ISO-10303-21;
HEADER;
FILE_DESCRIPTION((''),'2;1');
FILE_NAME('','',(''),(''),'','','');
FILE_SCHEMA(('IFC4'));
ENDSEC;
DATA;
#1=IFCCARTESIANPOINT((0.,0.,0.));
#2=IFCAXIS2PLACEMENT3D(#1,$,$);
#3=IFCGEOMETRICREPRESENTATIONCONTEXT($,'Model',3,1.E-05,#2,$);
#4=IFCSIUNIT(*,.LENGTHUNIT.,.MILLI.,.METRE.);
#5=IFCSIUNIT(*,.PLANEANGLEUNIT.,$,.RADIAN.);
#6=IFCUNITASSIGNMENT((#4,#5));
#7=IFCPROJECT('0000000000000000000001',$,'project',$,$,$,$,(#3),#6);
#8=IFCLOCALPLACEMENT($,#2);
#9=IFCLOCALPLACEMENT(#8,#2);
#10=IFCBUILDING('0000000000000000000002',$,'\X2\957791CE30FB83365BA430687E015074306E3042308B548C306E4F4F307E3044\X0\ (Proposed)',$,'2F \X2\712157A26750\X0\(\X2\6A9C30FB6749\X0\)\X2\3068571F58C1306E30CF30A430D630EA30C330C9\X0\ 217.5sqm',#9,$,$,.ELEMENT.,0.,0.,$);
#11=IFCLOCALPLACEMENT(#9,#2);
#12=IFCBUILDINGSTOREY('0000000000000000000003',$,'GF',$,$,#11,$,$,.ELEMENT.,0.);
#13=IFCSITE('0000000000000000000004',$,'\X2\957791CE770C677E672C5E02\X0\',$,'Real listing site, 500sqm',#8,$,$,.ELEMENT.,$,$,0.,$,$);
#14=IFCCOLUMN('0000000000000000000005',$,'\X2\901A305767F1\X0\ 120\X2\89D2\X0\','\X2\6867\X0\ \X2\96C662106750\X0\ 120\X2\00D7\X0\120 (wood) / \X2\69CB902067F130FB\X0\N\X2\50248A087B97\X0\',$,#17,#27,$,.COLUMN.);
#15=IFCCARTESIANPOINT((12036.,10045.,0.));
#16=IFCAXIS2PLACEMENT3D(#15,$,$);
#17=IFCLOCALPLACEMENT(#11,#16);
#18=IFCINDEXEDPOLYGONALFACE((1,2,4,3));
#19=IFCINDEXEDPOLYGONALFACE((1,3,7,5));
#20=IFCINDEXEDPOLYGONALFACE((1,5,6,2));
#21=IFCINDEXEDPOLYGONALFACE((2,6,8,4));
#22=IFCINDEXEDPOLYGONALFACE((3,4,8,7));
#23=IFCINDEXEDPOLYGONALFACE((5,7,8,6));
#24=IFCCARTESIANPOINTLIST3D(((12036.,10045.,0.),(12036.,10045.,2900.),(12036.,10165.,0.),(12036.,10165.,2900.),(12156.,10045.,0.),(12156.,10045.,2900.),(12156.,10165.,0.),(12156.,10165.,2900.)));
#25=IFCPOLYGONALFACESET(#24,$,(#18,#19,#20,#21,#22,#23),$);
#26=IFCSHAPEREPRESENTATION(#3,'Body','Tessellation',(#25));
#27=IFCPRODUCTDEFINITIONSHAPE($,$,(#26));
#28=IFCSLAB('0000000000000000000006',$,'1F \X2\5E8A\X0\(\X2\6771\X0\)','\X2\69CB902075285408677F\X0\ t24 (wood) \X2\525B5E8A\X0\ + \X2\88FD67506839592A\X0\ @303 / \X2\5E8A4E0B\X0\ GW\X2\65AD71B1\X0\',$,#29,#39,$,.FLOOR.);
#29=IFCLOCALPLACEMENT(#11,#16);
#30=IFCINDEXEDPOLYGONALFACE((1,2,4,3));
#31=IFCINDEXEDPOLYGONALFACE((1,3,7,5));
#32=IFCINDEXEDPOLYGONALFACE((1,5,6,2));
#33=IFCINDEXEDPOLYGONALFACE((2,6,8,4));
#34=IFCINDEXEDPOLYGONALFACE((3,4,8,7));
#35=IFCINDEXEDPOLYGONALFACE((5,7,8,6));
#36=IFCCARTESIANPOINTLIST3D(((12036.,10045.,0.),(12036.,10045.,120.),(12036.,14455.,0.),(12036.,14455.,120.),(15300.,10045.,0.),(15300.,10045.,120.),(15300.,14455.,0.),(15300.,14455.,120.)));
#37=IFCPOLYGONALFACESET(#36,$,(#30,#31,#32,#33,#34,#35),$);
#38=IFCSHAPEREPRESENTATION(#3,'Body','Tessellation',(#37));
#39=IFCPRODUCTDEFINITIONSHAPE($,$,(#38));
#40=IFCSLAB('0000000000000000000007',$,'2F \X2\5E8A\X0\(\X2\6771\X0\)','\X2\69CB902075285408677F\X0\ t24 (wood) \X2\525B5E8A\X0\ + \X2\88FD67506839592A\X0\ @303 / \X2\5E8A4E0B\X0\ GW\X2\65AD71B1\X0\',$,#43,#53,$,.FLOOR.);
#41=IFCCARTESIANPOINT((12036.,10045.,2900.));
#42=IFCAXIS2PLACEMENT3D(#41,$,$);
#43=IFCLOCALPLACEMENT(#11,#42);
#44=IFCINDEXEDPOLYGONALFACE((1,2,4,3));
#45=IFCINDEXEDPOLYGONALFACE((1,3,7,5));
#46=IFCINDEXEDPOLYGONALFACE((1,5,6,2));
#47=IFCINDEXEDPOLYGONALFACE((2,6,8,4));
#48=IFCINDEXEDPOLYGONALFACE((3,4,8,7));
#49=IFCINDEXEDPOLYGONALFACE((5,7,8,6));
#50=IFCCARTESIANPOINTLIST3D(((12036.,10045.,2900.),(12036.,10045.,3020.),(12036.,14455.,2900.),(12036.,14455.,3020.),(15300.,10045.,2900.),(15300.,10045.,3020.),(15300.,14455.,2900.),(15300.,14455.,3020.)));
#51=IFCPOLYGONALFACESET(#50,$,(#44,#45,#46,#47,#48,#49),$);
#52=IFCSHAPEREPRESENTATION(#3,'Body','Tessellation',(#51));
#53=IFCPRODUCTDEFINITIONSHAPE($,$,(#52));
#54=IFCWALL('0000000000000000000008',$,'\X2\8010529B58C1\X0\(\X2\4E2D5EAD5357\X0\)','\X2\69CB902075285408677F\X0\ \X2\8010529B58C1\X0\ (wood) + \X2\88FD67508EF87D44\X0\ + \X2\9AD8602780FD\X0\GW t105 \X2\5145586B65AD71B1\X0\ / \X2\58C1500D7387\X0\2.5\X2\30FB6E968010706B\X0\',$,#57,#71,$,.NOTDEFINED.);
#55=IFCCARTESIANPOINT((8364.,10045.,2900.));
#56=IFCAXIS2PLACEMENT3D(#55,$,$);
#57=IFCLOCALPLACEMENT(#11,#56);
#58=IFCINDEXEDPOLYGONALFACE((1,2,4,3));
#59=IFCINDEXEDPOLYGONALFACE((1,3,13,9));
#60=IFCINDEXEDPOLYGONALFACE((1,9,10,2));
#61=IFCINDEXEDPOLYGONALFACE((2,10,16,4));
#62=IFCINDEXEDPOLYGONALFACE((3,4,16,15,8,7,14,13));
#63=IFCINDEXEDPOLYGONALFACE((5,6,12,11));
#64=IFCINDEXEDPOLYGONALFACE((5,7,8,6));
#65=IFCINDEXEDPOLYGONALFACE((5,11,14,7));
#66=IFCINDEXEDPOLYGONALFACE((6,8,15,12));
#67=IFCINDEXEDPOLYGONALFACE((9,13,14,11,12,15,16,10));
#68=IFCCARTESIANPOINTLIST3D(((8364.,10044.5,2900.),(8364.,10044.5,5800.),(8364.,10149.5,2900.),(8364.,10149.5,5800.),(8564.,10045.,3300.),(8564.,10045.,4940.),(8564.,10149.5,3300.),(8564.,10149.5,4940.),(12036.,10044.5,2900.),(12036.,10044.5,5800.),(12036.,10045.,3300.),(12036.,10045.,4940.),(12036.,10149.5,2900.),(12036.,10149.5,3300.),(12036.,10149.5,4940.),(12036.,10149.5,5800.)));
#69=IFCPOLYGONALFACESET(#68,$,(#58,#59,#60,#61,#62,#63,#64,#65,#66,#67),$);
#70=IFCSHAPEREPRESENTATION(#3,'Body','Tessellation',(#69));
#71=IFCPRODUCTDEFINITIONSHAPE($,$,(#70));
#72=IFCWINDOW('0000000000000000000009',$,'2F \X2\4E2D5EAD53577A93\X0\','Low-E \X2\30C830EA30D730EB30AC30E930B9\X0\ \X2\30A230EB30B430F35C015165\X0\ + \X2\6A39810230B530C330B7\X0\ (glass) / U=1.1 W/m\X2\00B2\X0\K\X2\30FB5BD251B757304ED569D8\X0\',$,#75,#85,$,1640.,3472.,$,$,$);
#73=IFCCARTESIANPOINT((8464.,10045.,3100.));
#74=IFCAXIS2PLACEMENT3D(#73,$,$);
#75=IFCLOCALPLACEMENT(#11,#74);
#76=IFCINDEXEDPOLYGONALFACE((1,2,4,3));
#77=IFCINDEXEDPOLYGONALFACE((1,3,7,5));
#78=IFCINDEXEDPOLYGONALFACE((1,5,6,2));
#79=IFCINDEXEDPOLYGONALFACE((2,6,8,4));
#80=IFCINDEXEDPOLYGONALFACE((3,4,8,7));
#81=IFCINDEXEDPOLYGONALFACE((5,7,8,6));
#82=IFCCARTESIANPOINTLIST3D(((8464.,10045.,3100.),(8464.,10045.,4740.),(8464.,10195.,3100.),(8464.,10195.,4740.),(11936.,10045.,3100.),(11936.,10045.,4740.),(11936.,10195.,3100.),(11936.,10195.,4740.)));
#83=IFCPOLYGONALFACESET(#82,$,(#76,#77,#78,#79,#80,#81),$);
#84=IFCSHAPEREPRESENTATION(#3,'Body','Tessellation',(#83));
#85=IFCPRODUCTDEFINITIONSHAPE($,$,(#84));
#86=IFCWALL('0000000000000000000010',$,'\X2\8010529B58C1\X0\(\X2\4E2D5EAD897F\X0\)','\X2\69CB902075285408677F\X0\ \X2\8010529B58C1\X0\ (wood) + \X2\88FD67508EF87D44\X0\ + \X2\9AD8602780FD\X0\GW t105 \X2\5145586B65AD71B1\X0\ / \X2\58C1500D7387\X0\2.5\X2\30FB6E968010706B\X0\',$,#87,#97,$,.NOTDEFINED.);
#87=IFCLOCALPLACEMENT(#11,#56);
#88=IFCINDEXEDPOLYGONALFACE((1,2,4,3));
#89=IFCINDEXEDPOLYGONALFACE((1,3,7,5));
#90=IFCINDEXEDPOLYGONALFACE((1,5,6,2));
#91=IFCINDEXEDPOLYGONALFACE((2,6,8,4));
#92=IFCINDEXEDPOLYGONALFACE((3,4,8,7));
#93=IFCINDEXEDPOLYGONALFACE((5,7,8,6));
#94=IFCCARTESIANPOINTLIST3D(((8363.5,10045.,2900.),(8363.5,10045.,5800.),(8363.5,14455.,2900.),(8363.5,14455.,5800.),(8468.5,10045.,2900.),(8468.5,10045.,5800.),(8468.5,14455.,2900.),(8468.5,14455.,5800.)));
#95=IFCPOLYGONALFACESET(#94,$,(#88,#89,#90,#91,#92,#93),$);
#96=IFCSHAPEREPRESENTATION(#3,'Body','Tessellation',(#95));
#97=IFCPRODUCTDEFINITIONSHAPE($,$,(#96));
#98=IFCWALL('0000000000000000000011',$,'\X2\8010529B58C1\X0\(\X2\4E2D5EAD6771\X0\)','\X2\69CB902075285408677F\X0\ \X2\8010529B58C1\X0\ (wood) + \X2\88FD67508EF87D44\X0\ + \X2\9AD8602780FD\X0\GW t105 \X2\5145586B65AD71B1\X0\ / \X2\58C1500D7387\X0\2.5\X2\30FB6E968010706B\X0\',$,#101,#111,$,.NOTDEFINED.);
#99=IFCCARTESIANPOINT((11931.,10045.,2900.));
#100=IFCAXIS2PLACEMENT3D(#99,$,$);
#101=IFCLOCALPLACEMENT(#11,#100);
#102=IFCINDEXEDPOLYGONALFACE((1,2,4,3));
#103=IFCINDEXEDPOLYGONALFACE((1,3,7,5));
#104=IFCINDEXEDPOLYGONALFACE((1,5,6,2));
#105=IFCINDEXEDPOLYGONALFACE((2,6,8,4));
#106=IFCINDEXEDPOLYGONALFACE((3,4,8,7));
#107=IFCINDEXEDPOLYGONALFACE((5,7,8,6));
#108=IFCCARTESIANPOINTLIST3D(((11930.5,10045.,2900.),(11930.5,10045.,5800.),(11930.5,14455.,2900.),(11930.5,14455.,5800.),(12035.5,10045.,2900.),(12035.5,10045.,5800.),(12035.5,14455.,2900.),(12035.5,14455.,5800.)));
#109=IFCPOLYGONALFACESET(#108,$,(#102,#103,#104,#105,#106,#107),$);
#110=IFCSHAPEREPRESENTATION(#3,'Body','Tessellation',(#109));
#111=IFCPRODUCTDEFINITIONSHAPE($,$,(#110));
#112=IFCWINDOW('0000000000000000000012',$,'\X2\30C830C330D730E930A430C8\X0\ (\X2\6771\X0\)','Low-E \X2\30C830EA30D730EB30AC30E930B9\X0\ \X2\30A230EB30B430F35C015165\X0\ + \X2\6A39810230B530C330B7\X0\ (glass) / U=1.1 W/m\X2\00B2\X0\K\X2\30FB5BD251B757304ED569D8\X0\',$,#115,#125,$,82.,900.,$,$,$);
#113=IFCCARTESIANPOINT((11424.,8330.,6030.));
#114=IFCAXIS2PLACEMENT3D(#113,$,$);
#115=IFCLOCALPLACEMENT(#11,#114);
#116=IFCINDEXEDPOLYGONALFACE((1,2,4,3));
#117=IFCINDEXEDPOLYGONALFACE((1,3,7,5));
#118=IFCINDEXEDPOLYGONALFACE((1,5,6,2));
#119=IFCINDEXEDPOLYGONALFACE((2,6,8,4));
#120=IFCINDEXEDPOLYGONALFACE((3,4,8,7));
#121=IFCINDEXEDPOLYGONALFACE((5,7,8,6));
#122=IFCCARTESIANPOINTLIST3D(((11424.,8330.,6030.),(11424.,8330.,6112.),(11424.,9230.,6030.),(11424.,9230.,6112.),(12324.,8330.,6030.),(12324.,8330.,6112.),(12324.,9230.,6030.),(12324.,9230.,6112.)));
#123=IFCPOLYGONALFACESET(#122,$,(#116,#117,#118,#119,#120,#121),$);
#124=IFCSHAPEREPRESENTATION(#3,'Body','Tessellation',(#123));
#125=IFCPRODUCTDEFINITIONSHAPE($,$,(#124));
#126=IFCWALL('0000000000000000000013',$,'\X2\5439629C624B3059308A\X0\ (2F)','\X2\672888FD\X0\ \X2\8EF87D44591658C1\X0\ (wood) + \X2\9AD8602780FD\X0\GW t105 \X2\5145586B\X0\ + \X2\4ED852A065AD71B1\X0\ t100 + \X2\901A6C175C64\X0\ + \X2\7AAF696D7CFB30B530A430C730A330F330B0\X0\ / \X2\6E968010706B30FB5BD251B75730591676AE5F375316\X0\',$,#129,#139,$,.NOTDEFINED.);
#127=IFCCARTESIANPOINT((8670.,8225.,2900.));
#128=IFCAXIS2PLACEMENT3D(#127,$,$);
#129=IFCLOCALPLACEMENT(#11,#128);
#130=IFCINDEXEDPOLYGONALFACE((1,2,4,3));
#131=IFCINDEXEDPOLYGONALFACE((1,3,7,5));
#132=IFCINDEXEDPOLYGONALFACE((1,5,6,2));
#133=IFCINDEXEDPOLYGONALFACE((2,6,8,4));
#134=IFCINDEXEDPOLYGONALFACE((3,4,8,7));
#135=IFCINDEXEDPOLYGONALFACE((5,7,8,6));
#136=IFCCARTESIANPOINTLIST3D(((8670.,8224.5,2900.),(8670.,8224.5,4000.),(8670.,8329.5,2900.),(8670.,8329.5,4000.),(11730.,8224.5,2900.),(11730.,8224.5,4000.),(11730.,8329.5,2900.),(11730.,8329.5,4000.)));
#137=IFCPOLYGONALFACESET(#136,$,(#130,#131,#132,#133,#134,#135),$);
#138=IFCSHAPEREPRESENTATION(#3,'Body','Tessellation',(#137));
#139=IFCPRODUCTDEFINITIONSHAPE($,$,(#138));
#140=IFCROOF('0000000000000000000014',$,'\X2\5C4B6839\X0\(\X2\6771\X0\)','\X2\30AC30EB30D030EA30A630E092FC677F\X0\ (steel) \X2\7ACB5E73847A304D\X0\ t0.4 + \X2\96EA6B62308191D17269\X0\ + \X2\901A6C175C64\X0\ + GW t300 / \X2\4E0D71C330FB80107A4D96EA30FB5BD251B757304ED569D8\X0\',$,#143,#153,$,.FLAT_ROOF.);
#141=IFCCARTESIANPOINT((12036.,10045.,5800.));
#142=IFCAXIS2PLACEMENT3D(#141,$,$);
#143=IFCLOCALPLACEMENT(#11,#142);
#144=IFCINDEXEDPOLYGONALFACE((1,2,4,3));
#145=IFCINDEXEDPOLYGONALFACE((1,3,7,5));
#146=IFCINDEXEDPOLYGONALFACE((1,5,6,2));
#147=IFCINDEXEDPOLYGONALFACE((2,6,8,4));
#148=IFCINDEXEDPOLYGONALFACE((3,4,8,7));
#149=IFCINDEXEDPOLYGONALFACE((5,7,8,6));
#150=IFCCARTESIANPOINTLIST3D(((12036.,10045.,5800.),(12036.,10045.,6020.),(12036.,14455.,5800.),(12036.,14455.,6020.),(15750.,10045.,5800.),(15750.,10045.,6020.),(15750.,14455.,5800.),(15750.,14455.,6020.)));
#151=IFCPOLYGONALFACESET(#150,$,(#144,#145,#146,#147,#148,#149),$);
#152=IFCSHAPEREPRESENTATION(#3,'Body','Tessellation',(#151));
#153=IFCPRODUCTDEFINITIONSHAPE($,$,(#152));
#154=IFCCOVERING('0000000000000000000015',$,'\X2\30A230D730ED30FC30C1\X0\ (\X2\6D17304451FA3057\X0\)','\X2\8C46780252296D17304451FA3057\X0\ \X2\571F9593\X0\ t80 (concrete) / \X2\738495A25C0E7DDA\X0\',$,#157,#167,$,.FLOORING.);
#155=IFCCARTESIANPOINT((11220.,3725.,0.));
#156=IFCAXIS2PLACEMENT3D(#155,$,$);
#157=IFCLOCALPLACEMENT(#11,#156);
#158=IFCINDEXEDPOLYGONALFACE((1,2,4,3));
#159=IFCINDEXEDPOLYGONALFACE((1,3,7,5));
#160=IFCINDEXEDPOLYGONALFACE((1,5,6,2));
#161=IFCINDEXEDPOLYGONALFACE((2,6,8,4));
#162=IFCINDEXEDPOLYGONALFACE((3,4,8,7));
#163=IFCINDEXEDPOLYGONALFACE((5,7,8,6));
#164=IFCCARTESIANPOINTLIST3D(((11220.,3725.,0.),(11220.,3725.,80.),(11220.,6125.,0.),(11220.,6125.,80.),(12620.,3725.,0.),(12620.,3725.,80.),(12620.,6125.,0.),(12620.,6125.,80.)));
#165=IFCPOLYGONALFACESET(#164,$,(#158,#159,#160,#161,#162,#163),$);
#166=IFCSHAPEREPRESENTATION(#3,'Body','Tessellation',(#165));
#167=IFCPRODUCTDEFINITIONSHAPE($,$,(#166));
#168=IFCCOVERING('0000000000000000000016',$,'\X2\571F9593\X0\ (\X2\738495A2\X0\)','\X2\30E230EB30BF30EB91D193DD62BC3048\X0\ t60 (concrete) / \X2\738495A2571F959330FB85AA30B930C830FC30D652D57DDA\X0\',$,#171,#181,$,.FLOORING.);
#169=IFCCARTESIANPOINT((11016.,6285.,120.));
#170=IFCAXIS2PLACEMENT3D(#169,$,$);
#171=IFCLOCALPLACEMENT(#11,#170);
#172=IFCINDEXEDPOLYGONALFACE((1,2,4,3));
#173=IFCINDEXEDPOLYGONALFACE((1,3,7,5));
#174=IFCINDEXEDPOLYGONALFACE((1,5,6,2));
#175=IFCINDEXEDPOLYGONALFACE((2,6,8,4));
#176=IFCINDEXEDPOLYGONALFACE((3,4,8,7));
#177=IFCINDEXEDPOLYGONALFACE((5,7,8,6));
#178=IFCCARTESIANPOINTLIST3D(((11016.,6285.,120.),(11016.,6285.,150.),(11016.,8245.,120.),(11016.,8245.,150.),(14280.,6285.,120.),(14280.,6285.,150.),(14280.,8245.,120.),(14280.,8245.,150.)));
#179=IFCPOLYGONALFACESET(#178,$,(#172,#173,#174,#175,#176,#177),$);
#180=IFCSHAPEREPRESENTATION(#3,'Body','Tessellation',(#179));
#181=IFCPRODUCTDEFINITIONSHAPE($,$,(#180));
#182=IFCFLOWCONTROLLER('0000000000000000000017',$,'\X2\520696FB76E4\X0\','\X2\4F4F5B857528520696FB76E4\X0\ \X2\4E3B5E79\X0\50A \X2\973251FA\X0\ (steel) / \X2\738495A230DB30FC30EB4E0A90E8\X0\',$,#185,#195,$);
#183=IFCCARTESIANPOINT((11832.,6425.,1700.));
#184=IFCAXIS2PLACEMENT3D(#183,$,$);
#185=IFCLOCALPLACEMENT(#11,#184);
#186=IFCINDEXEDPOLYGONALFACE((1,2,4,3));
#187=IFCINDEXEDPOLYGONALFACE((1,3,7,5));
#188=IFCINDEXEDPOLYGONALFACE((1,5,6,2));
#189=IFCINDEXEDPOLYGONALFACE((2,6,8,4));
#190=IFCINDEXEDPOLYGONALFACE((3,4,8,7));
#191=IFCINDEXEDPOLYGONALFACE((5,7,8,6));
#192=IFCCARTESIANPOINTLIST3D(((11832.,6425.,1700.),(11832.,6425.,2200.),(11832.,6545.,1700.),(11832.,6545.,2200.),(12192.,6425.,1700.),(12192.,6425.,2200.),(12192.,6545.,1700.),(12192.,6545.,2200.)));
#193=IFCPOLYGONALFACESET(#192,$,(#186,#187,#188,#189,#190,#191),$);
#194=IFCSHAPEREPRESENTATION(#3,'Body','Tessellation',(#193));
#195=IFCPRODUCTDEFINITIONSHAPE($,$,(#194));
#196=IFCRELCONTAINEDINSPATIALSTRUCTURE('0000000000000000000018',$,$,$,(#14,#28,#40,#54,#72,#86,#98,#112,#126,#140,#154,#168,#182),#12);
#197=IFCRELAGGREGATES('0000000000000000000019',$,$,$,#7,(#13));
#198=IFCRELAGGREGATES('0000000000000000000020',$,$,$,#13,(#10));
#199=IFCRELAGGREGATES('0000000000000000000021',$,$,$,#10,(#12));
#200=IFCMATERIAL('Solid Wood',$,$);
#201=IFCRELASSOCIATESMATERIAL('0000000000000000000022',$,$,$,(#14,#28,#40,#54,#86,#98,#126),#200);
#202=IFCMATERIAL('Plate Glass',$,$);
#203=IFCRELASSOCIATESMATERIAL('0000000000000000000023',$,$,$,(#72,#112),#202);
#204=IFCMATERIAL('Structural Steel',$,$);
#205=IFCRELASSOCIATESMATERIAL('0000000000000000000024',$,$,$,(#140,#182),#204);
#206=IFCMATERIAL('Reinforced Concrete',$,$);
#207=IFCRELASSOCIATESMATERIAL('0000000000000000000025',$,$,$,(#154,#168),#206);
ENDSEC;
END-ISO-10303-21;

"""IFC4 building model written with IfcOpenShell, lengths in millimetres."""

from ifc_helpers import new_model, si_unit, frame, frame_2d, origin, place, context, project, spatial, rectangle, extrude, material, element, fill, save


model = new_model("IFC4")

# Units and contexts
model_context = context("Model", 3, precision=1e-05, world=origin())
ifc_project = project(units=[si_unit("LENGTHUNIT", "METRE", prefix="MILLI"), si_unit("PLANEANGLEUNIT", "RADIAN")], contexts=[model_context])

# Site, building, storey
site_placement = place(None, origin())
site = spatial("IfcSite", under=ifc_project, at=site_placement, Name="長野県松本市", ObjectType="Real listing site, 500sqm", CompositionType="ELEMENT", RefElevation=0.0)
building_placement = place(site_placement, origin())
building = spatial("IfcBuilding", under=site, at=building_placement, Name="長野・茶室と縁側のある和の住まい (Proposed)", ObjectType="2F 無垢材(檜・杉)と土壁のハイブリッド 217.5sqm", CompositionType="ELEMENT", ElevationOfRefHeight=0.0, ElevationOfTerrain=0.0)
storey_placement = place(building_placement, origin())
storey = spatial("IfcBuildingStorey", under=building, at=storey_placement, Name="GF", CompositionType="ELEMENT", Elevation=0.0)

# Column
ifc_material_1 = material(Name="Solid Wood")
column_1_placement = place(storey_placement, frame((12036.0, 10045.0, 0.0)))
element("IfcColumn", 1, at=column_1_placement, inside=storey, material=ifc_material_1, Name="通し柱 120角", Description="桧 集成材 120×120 (wood) / 構造柱・N値計算", PredefinedType="COLUMN", context=model_context, shape_type="SweptSolid", body=[
    extrude(rectangle(XDim=120.0, YDim=120.0, at=frame_2d((60.0, 60.0))), frame((12036.0, 10045.0, 0.0)), (0.0, 0.0, 1.0), 2900.0),
])

# Slabs
slab_1_placement = place(storey_placement, frame((12036.0, 10045.0, 0.0)))
element("IfcSlab", 2, at=slab_1_placement, inside=storey, material=ifc_material_1, Name="1F 床(東)", Description="構造用合板 t24 (wood) 剛床 + 製材根太 @303 / 床下 GW断熱", PredefinedType="FLOOR", context=model_context, shape_type="SweptSolid", body=[
    extrude(rectangle(XDim=3264.0, YDim=4410.0, at=frame_2d((1632.0, 2205.0))), frame((12036.0, 10045.0, 0.0)), (0.0, 0.0, 1.0), 120.0),
])
slab_2_placement = place(storey_placement, frame((12036.0, 10045.0, 2900.0)))
element("IfcSlab", 3, at=slab_2_placement, inside=storey, material=ifc_material_1, Name="2F 床(東)", Description="構造用合板 t24 (wood) 剛床 + 製材根太 @303 / 床下 GW断熱", PredefinedType="FLOOR", context=model_context, shape_type="SweptSolid", body=[
    extrude(rectangle(XDim=3264.0, YDim=4410.0, at=frame_2d((1632.0, 2205.0))), frame((12036.0, 10045.0, 2900.0)), (0.0, 0.0, 1.0), 120.0),
])

# Wall, opening, window
wall_1_placement = place(storey_placement, frame((8364.0, 10045.0, 2900.0)))
wall_1 = element("IfcWall", 4, at=wall_1_placement, inside=storey, material=ifc_material_1, Name="耐力壁(中庭南)", Description="構造用合板 耐力壁 (wood) + 製材軸組 + 高性能GW t105 充填断熱 / 壁倍率2.5・準耐火", PredefinedType="NOTDEFINED", context=model_context, shape_type="SweptSolid", body=[
    extrude(rectangle(XDim=3672.0, YDim=105.0, at=frame_2d((1836.0, 52.0))), frame((8364.0, 10045.0, 2900.0)), (0.0, 0.0, 1.0), 2900.0),
])
opening_placement = place(storey_placement, frame((8464.0, 10045.0, 3100.0)))
opening = element("IfcOpeningElement", 5, at=opening_placement, cuts=wall_1, PredefinedType="NOTDEFINED", context=model_context, shape_type="SweptSolid", body=[
    extrude(rectangle(XDim=3472.0, YDim=150.0, at=frame_2d((1736.0, 75.0))), frame((8464.0, 10045.0, 3100.0)), (0.0, 0.0, 1.0), 1640.0),
])
ifc_material_2 = material(Name="Plate Glass")
window_1_placement = place(storey_placement, frame((8464.0, 10045.0, 3100.0)))
window_1 = element("IfcWindow", 6, at=window_1_placement, inside=storey, material=ifc_material_2, Name="2F 中庭南窓", Description="Low-E トリプルガラス アルゴン封入 + 樹脂サッシ (glass) / U=1.1 W/m²K・寒冷地仕様", OverallHeight=1640.0, OverallWidth=3472.0, context=model_context, shape_type="SweptSolid", body=[
    extrude(rectangle(XDim=3472.0, YDim=150.0, at=frame_2d((1736.0, 75.0))), frame((8464.0, 10045.0, 3100.0)), (0.0, 0.0, 1.0), 1640.0),
])
fill(opening, window_1)

# Walls
wall_2_placement = place(storey_placement, frame((8364.0, 10045.0, 2900.0)))
element("IfcWall", 7, at=wall_2_placement, inside=storey, material=ifc_material_1, Name="耐力壁(中庭西)", Description="構造用合板 耐力壁 (wood) + 製材軸組 + 高性能GW t105 充填断熱 / 壁倍率2.5・準耐火", PredefinedType="NOTDEFINED", context=model_context, shape_type="SweptSolid", body=[
    extrude(rectangle(XDim=105.0, YDim=4410.0, at=frame_2d((52.0, 2205.0))), frame((8364.0, 10045.0, 2900.0)), (0.0, 0.0, 1.0), 2900.0),
])
wall_3_placement = place(storey_placement, frame((11931.0, 10045.0, 2900.0)))
element("IfcWall", 8, at=wall_3_placement, inside=storey, material=ifc_material_1, Name="耐力壁(中庭東)", Description="構造用合板 耐力壁 (wood) + 製材軸組 + 高性能GW t105 充填断熱 / 壁倍率2.5・準耐火", PredefinedType="NOTDEFINED", context=model_context, shape_type="SweptSolid", body=[
    extrude(rectangle(XDim=105.0, YDim=4410.0, at=frame_2d((52.0, 2205.0))), frame((11931.0, 10045.0, 2900.0)), (0.0, 0.0, 1.0), 2900.0),
])

# Window
window_2_placement = place(storey_placement, frame((11424.0, 8330.0, 6030.0)))
element("IfcWindow", 9, at=window_2_placement, inside=storey, material=ifc_material_2, Name="トップライト (東)", Description="Low-E トリプルガラス アルゴン封入 + 樹脂サッシ (glass) / U=1.1 W/m²K・寒冷地仕様", OverallHeight=82.0, OverallWidth=900.0, context=model_context, shape_type="SweptSolid", body=[
    extrude(rectangle(XDim=900.0, YDim=900.0, at=frame_2d((450.0, 450.0))), frame((11424.0, 8330.0, 6030.0)), (0.0, 0.0, 1.0), 82.0),
])

# Wall
wall_4_placement = place(storey_placement, frame((8670.0, 8225.0, 2900.0)))
element("IfcWall", 10, at=wall_4_placement, inside=storey, material=ifc_material_1, Name="吹抜手すり (2F)", Description="木製 軸組外壁 (wood) + 高性能GW t105 充填 + 付加断熱 t100 + 通気層 + 窯業系サイディング / 準耐火・寒冷地外皮強化", PredefinedType="NOTDEFINED", context=model_context, shape_type="SweptSolid", body=[
    extrude(rectangle(XDim=3060.0, YDim=105.0, at=frame_2d((1530.0, 52.0))), frame((8670.0, 8225.0, 2900.0)), (0.0, 0.0, 1.0), 1100.0),
])

# Roof
ifc_material_3 = material(Name="Structural Steel")
for number, where, name in (
    (11, (12036.0, 10045.0, 5800.0), "屋根(東)"),
):
    element("IfcRoof", number, at=place(storey_placement, frame(where)), inside=storey, material=ifc_material_3, Name=name, Description="ガルバリウム鋼板 (steel) 立平葺き t0.4 + 雪止め金物 + 通気層 + GW t300 / 不燃・耐積雪・寒冷地仕様", PredefinedType="FLAT_ROOF", context=model_context, shape_type="SweptSolid", body=[
        extrude(rectangle(XDim=3714.0, YDim=4410.0, at=frame_2d((1857.0, 2205.0))), frame((12036.0, 10045.0, 5800.0)), (0.0, 0.0, 1.0), 220.0),
    ])

# Coverings
ifc_material_4 = material(Name="Reinforced Concrete")
covering_1_placement = place(storey_placement, frame((11220.0, 3725.0, 0.0)))
element("IfcCovering", 12, at=covering_1_placement, inside=storey, material=ifc_material_4, Name="アプローチ (洗い出し)", Description="豆砂利洗い出し 土間 t80 (concrete) / 玄関導線", PredefinedType="FLOORING", context=model_context, shape_type="SweptSolid", body=[
    extrude(rectangle(XDim=1400.0, YDim=2400.0, at=frame_2d((700.0, 1200.0))), frame((11220.0, 3725.0, 0.0)), (0.0, 0.0, 1.0), 80.0),
])
covering_2_placement = place(storey_placement, frame((11016.0, 6285.0, 120.0)))
element("IfcCovering", 13, at=covering_2_placement, inside=storey, material=ifc_material_4, Name="土間 (玄関)", Description="モルタル金鏝押え t60 (concrete) / 玄関土間・薪ストーブ動線", PredefinedType="FLOORING", context=model_context, shape_type="SweptSolid", body=[
    extrude(rectangle(XDim=3264.0, YDim=1960.0, at=frame_2d((1632.0, 980.0))), frame((11016.0, 6285.0, 120.0)), (0.0, 0.0, 1.0), 30.0),
])

# Flow controller
flow_controller_placement = place(storey_placement, frame((11832.0, 6425.0, 1700.0)))
element("IfcFlowController", 14, at=flow_controller_placement, inside=storey, material=ifc_material_3, Name="分電盤", Description="住宅用分電盤 主幹50A 露出 (steel) / 玄関ホール上部", context=model_context, shape_type="SweptSolid", body=[
    extrude(rectangle(XDim=360.0, YDim=120.0, at=frame_2d((180.0, 60.0))), frame((11832.0, 6425.0, 1700.0)), (0.0, 0.0, 1.0), 500.0),
])

save(model, "model.ifc")
